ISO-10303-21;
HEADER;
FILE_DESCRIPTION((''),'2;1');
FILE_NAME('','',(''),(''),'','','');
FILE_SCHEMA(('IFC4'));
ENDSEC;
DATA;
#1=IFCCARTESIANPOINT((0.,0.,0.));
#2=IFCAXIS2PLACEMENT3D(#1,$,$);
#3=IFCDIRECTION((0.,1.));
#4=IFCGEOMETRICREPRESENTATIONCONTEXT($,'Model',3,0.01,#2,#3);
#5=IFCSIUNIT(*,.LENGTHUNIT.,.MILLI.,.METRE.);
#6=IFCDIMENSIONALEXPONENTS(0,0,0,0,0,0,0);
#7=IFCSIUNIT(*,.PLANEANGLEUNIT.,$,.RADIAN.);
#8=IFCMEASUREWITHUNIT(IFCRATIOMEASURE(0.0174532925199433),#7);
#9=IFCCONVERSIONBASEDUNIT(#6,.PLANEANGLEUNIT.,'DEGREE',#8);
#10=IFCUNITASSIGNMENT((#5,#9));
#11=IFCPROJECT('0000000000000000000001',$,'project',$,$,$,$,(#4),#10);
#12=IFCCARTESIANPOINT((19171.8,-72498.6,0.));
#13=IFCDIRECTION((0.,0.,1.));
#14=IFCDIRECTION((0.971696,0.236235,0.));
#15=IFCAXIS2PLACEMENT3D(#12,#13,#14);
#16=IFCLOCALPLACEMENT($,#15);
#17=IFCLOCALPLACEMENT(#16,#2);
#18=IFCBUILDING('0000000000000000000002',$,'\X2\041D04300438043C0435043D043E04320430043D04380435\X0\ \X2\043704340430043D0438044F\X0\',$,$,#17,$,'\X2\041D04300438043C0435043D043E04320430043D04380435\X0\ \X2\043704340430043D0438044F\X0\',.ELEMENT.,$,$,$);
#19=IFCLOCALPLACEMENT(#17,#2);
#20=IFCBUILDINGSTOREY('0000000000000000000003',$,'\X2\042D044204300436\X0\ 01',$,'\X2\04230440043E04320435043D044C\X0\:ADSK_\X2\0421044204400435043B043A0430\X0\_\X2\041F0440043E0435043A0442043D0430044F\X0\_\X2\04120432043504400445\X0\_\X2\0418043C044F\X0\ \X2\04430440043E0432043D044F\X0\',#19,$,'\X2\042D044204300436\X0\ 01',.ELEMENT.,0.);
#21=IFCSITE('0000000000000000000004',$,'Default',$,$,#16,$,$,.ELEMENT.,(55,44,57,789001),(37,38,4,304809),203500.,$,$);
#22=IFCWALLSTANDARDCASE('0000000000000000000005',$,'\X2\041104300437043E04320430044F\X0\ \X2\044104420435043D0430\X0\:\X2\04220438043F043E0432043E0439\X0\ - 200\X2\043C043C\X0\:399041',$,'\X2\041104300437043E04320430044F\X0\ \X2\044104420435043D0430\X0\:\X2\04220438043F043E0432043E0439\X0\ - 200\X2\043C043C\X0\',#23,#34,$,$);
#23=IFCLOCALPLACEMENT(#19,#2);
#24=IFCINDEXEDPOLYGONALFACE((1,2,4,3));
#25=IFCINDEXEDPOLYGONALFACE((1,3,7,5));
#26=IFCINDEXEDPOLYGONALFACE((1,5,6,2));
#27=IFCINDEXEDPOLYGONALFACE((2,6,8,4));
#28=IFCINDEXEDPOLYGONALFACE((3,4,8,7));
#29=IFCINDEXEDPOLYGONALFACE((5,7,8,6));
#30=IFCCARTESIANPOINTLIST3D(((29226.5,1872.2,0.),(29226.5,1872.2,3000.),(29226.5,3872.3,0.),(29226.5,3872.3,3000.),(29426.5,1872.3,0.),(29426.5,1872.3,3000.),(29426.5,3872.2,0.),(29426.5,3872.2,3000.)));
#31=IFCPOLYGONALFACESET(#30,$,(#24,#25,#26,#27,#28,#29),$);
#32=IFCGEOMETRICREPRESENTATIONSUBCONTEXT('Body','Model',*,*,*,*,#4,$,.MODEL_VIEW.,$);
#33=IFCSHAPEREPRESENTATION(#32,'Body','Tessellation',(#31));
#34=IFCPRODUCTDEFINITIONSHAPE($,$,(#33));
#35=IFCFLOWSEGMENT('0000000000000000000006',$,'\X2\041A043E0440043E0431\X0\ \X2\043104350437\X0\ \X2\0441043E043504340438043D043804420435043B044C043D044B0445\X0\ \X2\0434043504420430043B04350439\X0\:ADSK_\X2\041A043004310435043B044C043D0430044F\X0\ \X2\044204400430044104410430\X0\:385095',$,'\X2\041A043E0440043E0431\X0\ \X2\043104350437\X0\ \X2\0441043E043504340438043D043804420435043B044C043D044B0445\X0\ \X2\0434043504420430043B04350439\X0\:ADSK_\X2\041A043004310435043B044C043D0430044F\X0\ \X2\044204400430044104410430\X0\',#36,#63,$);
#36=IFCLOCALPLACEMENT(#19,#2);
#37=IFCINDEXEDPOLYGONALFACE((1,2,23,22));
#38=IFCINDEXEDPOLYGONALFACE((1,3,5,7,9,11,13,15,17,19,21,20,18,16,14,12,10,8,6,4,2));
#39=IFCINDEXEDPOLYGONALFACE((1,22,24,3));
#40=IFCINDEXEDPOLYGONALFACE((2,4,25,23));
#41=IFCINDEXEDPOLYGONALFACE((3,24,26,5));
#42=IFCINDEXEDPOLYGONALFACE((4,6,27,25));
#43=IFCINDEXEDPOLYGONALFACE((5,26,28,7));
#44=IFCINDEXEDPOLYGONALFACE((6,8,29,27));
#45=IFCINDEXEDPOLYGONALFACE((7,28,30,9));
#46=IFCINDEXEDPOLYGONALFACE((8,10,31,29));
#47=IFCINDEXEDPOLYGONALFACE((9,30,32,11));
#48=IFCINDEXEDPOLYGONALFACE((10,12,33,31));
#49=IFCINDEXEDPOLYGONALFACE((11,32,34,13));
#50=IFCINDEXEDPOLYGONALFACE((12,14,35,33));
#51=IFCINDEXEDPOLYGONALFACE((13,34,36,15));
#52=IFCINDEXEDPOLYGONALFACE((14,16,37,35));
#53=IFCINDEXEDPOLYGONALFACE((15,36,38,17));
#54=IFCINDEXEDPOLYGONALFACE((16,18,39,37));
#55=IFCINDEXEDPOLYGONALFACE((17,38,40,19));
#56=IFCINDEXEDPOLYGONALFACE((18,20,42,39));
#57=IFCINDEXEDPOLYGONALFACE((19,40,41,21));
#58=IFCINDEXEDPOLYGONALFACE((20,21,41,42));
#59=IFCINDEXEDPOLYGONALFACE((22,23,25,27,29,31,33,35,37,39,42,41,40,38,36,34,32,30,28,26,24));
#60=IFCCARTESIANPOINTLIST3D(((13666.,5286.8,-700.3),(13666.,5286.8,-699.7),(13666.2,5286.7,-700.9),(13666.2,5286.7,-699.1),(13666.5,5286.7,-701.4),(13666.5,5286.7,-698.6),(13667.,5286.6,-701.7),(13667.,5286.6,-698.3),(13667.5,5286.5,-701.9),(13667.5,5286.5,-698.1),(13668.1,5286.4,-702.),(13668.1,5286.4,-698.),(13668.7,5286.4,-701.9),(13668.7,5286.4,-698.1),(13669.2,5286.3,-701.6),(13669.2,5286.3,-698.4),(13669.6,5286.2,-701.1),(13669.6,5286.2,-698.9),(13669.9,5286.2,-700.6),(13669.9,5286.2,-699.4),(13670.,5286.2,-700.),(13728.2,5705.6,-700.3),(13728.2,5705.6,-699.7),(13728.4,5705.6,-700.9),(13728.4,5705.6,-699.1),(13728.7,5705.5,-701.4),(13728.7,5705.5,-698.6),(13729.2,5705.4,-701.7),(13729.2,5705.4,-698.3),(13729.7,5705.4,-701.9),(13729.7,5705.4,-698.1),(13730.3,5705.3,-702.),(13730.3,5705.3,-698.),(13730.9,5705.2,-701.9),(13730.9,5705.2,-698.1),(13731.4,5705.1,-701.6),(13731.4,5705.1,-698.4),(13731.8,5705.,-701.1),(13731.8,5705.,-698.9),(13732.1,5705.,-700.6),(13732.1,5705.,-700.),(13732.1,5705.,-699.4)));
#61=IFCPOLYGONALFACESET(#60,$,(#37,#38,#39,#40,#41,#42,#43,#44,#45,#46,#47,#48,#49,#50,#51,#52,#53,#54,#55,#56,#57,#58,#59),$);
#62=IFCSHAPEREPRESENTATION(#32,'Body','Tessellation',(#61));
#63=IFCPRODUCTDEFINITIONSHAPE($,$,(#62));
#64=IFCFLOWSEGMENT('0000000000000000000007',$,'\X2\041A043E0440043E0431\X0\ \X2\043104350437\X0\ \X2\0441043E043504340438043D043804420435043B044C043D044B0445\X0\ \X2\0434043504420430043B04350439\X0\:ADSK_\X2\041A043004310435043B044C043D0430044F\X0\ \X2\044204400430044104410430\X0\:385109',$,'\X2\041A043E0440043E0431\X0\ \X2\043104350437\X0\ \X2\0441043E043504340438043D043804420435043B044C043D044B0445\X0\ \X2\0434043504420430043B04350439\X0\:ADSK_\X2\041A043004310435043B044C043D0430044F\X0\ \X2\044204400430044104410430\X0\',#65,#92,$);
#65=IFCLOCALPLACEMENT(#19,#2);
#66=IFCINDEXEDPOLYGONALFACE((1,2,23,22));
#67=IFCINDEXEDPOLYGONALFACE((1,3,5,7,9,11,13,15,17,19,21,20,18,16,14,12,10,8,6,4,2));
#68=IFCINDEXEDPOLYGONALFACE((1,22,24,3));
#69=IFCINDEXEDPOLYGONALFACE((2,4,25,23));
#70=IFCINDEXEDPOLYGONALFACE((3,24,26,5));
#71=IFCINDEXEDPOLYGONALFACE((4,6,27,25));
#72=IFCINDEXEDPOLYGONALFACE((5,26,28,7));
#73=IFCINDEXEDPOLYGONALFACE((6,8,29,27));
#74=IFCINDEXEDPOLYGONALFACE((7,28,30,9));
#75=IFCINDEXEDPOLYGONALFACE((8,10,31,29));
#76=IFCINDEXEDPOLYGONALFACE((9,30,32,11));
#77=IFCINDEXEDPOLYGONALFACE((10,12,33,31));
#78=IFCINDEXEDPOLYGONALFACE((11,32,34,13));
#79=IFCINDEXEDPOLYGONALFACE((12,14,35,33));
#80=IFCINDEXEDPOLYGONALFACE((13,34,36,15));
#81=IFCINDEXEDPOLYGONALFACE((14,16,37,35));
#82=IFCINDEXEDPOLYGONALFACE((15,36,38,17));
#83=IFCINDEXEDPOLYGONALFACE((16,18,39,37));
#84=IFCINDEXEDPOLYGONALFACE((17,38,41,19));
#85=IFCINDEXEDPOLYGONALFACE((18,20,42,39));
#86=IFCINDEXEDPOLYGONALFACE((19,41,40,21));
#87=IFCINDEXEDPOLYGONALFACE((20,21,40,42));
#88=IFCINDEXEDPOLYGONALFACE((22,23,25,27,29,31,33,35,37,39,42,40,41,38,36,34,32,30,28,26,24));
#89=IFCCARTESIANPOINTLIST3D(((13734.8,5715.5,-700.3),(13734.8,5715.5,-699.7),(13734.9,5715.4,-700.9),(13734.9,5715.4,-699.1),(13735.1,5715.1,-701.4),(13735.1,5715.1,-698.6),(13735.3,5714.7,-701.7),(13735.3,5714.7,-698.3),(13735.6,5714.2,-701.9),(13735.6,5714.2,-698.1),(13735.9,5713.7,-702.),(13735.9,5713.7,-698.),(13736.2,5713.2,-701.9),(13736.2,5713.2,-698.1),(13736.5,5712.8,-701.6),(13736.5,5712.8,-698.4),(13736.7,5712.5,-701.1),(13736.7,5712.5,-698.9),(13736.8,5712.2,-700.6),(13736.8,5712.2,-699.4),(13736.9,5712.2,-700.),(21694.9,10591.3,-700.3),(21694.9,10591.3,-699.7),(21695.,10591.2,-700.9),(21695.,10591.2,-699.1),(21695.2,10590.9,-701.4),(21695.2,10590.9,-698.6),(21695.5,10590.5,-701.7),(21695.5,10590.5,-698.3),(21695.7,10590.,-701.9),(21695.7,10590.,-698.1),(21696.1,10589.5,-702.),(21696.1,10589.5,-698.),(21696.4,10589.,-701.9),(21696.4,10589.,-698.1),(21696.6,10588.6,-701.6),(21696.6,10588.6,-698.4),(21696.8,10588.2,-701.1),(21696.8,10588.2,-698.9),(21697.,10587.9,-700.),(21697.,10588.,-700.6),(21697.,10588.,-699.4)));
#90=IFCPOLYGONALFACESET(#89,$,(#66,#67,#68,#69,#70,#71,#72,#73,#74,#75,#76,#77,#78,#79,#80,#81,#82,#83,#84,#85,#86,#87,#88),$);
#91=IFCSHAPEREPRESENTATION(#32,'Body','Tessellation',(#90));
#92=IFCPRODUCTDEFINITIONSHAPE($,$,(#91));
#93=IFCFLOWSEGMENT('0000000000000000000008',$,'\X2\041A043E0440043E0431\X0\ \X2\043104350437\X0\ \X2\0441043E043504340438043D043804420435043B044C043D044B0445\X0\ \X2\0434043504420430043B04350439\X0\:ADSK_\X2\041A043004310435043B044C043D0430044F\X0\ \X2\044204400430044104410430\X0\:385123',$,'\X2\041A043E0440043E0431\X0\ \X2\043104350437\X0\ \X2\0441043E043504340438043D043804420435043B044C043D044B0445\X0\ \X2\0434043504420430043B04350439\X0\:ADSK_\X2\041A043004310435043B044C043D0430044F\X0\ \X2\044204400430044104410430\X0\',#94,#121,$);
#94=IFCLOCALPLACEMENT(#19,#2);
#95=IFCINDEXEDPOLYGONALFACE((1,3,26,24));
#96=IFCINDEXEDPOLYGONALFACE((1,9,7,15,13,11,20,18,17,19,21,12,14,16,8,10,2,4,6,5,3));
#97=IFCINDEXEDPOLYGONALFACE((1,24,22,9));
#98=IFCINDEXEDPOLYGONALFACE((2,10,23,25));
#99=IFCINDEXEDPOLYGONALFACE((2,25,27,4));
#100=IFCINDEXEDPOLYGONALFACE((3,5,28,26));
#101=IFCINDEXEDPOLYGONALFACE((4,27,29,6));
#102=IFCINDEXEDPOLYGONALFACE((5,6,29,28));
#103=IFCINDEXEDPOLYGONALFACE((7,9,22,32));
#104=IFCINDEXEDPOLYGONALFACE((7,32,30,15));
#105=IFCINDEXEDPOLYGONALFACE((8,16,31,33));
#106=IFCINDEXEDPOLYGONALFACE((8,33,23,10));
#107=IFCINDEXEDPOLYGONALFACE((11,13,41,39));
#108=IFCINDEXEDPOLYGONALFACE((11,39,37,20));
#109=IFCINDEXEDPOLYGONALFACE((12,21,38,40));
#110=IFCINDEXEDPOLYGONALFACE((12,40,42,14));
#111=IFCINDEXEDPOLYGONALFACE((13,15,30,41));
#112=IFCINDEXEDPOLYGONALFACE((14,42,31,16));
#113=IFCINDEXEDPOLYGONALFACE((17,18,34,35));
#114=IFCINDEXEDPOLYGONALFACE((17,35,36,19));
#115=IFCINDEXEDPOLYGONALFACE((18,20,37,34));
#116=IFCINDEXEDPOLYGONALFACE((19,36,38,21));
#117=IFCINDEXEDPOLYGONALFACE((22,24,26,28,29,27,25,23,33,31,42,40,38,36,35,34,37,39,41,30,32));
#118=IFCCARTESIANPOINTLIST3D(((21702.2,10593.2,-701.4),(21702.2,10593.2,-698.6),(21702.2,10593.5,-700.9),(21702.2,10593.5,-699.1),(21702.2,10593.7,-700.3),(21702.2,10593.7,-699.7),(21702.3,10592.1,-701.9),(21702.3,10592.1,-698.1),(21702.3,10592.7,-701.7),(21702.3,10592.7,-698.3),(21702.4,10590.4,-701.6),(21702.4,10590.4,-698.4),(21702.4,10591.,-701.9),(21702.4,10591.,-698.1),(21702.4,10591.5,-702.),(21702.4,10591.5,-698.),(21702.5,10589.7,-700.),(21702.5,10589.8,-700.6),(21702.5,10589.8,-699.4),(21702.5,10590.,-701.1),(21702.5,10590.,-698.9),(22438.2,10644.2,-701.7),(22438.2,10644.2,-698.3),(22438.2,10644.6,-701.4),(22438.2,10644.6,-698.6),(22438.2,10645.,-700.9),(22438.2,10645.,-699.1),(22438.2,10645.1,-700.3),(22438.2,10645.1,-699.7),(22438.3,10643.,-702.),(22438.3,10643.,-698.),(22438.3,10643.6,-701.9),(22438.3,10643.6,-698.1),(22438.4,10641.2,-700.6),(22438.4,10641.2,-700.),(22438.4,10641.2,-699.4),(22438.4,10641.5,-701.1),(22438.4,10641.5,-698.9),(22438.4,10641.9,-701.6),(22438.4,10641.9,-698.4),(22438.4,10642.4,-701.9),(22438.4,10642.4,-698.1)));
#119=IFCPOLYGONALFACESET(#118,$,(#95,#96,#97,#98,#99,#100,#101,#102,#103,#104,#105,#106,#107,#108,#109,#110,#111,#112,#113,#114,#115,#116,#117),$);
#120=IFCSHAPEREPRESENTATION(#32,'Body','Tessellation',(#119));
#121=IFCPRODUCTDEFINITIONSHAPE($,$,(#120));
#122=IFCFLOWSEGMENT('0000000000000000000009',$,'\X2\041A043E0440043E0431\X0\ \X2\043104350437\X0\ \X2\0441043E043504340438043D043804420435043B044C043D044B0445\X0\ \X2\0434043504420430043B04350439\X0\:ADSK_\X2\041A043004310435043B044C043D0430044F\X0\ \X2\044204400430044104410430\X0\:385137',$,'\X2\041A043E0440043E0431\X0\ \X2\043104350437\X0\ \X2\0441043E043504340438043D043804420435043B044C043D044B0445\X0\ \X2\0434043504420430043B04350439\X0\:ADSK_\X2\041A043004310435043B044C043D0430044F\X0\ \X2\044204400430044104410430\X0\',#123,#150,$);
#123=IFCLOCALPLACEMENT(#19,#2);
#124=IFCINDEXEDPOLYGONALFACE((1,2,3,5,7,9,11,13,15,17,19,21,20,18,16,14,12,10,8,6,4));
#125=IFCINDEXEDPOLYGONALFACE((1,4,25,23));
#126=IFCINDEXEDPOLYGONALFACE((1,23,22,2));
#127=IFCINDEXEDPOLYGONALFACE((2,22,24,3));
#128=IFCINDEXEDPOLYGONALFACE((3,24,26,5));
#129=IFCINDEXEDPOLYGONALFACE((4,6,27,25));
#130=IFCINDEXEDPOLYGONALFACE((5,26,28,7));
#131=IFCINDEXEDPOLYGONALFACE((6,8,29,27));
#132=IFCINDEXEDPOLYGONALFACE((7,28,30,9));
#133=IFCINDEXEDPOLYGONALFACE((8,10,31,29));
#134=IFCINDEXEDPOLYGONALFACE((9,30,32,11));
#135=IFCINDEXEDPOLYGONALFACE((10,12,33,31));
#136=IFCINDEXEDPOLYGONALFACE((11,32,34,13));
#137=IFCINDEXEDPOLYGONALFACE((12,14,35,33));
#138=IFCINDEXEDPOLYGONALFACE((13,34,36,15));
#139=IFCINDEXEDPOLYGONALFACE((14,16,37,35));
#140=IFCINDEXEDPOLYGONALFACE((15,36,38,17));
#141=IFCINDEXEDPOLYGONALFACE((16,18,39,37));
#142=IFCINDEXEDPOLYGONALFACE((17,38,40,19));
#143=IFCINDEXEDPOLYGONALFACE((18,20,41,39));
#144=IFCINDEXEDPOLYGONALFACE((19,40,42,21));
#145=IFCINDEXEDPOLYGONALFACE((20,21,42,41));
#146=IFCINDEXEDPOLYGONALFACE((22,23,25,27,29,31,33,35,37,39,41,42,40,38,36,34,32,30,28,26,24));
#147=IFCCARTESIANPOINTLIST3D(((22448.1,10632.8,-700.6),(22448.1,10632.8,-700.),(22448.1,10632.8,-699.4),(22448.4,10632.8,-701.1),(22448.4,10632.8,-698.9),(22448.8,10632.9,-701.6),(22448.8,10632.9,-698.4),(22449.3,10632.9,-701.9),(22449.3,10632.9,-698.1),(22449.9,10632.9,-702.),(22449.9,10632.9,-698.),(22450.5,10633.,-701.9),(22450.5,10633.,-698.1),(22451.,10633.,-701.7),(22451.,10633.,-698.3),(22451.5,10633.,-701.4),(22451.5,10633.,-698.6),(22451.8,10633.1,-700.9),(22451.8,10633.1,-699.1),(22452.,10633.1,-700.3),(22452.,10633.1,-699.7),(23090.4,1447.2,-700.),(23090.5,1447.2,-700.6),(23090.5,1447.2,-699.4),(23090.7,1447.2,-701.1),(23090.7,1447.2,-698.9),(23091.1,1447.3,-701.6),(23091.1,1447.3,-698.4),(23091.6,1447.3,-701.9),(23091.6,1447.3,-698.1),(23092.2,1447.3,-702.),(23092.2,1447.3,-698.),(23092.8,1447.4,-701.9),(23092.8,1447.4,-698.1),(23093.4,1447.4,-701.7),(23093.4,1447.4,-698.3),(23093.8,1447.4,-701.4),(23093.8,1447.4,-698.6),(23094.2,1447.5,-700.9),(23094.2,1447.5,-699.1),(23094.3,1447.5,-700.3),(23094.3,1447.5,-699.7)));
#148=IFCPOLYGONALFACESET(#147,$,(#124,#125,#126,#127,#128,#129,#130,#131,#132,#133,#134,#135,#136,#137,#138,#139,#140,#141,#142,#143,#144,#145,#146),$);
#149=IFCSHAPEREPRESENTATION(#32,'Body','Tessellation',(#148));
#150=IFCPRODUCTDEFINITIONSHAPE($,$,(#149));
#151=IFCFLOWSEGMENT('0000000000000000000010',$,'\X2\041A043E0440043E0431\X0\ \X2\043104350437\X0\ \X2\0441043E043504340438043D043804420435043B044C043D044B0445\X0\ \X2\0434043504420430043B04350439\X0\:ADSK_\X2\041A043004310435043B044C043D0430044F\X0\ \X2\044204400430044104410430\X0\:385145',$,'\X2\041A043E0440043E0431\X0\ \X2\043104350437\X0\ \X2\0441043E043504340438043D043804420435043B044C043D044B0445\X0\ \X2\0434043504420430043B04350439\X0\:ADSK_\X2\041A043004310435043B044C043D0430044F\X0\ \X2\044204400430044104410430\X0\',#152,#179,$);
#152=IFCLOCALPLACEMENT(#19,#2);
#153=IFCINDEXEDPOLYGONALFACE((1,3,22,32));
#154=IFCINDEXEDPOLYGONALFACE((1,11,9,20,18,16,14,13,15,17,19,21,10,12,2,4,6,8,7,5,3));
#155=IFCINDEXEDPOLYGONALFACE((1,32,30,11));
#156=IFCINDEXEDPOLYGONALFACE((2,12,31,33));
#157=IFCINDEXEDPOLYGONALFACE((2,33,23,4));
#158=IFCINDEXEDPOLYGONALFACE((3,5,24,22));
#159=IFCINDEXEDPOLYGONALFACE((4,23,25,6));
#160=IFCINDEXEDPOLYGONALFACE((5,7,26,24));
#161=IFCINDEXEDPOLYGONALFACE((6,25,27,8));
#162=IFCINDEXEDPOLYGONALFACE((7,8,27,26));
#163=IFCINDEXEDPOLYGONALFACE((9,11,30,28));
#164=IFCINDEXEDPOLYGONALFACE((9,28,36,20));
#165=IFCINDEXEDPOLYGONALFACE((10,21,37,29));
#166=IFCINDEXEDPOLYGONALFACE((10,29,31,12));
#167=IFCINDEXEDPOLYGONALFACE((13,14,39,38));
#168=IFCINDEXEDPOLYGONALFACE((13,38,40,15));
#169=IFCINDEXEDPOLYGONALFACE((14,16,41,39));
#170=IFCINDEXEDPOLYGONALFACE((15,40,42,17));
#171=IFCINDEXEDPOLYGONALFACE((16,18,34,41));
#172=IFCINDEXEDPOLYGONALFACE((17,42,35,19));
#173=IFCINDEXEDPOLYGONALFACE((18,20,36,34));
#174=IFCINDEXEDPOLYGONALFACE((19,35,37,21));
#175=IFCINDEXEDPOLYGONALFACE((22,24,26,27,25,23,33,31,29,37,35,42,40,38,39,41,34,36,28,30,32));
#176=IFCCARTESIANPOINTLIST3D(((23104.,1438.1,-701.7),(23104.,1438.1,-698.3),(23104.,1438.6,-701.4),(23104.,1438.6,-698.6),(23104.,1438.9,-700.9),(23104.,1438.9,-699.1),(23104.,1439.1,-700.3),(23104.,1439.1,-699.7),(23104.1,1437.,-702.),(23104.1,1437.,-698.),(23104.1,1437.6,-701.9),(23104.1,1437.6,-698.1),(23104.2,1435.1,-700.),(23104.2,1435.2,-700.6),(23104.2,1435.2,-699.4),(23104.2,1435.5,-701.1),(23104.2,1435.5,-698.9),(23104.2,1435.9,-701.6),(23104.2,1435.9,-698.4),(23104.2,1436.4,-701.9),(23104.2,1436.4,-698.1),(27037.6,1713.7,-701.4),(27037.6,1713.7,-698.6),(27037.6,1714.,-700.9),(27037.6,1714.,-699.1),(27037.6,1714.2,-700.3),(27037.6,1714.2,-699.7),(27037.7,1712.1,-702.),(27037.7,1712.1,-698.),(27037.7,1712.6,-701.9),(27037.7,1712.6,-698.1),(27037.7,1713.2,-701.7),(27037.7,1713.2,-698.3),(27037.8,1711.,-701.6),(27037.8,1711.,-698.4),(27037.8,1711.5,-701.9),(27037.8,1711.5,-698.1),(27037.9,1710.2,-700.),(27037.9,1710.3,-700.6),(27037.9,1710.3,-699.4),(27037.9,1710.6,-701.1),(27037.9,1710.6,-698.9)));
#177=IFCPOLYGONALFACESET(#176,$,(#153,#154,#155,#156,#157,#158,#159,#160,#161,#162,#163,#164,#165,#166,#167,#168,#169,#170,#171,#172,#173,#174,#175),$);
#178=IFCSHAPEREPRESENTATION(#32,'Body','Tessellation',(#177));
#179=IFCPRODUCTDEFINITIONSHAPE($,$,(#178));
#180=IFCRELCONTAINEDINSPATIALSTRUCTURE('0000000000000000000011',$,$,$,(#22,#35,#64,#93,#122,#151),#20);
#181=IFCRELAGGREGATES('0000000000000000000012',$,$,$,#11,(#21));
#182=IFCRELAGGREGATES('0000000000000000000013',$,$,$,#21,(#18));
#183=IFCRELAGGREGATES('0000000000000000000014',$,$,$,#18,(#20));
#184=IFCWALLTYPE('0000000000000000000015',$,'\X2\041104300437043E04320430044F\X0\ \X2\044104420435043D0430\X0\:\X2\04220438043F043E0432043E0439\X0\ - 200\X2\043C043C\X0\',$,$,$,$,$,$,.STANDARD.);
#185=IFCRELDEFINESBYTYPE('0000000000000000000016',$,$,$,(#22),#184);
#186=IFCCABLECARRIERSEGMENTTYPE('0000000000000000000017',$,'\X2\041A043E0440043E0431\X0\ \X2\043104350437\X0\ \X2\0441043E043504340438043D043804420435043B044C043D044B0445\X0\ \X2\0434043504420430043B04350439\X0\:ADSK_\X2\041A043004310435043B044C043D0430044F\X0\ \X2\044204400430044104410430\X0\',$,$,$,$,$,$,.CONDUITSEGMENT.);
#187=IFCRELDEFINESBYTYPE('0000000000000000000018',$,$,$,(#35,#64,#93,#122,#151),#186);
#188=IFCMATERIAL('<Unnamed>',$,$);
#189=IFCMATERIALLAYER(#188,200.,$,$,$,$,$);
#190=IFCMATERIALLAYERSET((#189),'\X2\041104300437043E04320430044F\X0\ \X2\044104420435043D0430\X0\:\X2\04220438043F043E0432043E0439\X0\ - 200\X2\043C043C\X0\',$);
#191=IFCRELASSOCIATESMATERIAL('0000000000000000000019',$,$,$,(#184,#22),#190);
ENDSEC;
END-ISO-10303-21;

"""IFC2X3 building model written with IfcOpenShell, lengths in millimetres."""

from ifc_helpers import new_model, entity, si_unit, converted_unit, direction, frame, frame_2d, origin, origin_2d_with_axis, place, context, subcontext, project, spatial, rectangle, circle, extrude, material, layer, layer_set, layer_usage, type_object, element, save


model = new_model("IFC2X3")

# Units and contexts
model_context = context("Model", 3, precision=0.01, world=origin(), true_north=direction((0.0, 1.0)))
body_context = subcontext(model_context, "Body", "Model", "MODEL_VIEW")
ifc_project = project(units=[si_unit("LENGTHUNIT", "METRE", prefix="MILLI"), converted_unit("PLANEANGLEUNIT", "DEGREE", entity("IfcRatioMeasure", 0.0174532925199433), si_unit("PLANEANGLEUNIT", "RADIAN"), dimensions=[0, 0, 0, 0, 0, 0, 0])], contexts=[model_context])

# Site, building, storey
site_placement = place(None, frame((19171.8, -72498.6, 0.0), z_axis=(0.0, 0.0, 1.0), x_axis=(0.971696, 0.236235, 0.0)))
site = spatial("IfcSite", under=ifc_project, at=site_placement, Name="Default", CompositionType="ELEMENT", RefLatitude=(55, 44, 57, 789001), RefLongitude=(37, 38, 4, 304809), RefElevation=203500.0)
building_placement = place(site_placement, origin())
building = spatial("IfcBuilding", under=site, at=building_placement, Name="Наименование здания", LongName="Наименование здания", CompositionType="ELEMENT")
storey_placement = place(building_placement, origin())
storey = spatial("IfcBuildingStorey", under=building, at=storey_placement, Name="Этаж 01", ObjectType="Уровень:ADSK_Стрелка_Проектная_Вверх_Имя уровня", LongName="Этаж 01", CompositionType="ELEMENT", Elevation=0.0)

# Wall
ifc_material = material(Name="<Unnamed>")
ifc_layer = layer(ifc_material, 200.0)
ifc_layer_set = layer_set([ifc_layer], Name="Базовая стена:Типовой - 200мм")
ifc_layer_usage = layer_usage(ifc_layer_set, "AXIS2", "NEGATIVE", 100.0)
wall_type = type_object("IfcWallType", Name="Базовая стена:Типовой - 200мм", PredefinedType="STANDARD", material=ifc_layer_set)
wall_placement = place(storey_placement, frame((29326.5, 3872.2, 0.0), z_axis=(0.0, 0.0, 1.0), x_axis=(0.0, -1.0, 0.0)))
element("IfcWallStandardCase", 1, at=wall_placement, inside=storey, type_object=wall_type, material=ifc_layer_usage, Name="Базовая стена:Типовой - 200мм:399041", ObjectType="Базовая стена:Типовой - 200мм", context=body_context, shape_type="SweptSolid", body=[
    extrude(rectangle(XDim=2000.0, YDim=200.0, at=frame_2d((1000.0, 0.0), x_axis=(-1.0, 0.0))), origin(), (0.0, 0.0, 1.0), 3000.0),
])

# Flow segments
cable_carrier_segment_type_1 = type_object("IfcCableCarrierSegmentType", Name="Короб без соединительных деталей:ADSK_Кабельная трасса", PredefinedType="CONDUITSEGMENT")
flow_segment_1_placement = place(storey_placement, frame((13664.4, 5284.6, -703.6)))
element("IfcFlowSegment", 2, at=flow_segment_1_placement, inside=storey, type_object=cable_carrier_segment_type_1, Name="Короб без соединительных деталей:ADSK_Кабельная трасса:385095", ObjectType="Короб без соединительных деталей:ADSK_Кабельная трасса", context=body_context, shape_type="SweptSolid", body=[
    extrude(circle(Radius=2.0, at=origin_2d_with_axis()), frame((3.6, 1.9, 3.6), z_axis=(0.146835, 0.989161, 0.0), x_axis=(0.989161, -0.146835, 0.0)), (0.0, 0.0, 1.0), 423.4),
])
flow_segment_2_placement = place(storey_placement, frame((13733.2, 5710.6, -703.6)))
element("IfcFlowSegment", 3, at=flow_segment_2_placement, inside=storey, type_object=cable_carrier_segment_type_1, Name="Короб без соединительных деталей:ADSK_Кабельная трасса:385109", ObjectType="Короб без соединительных деталей:ADSK_Кабельная трасса", context=body_context, shape_type="SweptSolid", body=[
    extrude(circle(Radius=2.0, at=origin_2d_with_axis()), frame((2.6, 3.3, 3.6), z_axis=(0.852745, 0.522328, 0.0), x_axis=(0.522328, -0.852745, 0.0)), (0.0, 0.0, 1.0), 9334.7),
])
flow_segment_3_placement = place(storey_placement, frame((21702.2, 10588.1, -703.6)))
element("IfcFlowSegment", 4, at=flow_segment_3_placement, inside=storey, type_object=cable_carrier_segment_type_1, Name="Короб без соединительных деталей:ADSK_Кабельная трасса:385123", ObjectType="Короб без соединительных деталей:ADSK_Кабельная трасса", context=body_context, shape_type="SweptSolid", body=[
    extrude(circle(Radius=2.0, at=origin_2d_with_axis()), frame((0.1, 3.6, 3.6), z_axis=(0.997564, 0.069756, 0.0), x_axis=(0.069756, -0.997564, 0.0)), (0.0, 0.0, 1.0), 737.8),
])
flow_segment_4_placement = place(storey_placement, frame((22446.5, 1447.2, -703.6)))
element("IfcFlowSegment", 5, at=flow_segment_4_placement, inside=storey, type_object=cable_carrier_segment_type_1, Name="Короб без соединительных деталей:ADSK_Кабельная трасса:385137", ObjectType="Короб без соединительных деталей:ADSK_Кабельная трасса", context=body_context, shape_type="SweptSolid", body=[
    extrude(circle(Radius=2.0, at=origin_2d_with_axis()), frame((3.6, 9185.7, 3.6), z_axis=(0.069756, -0.997564, 0.0), x_axis=(-0.997564, -0.069756, 0.0)), (0.0, 0.0, 1.0), 9208.0),
])
flow_segment_5_placement = place(storey_placement, frame((23104.0, 1433.5, -703.6)))
element("IfcFlowSegment", 6, at=flow_segment_5_placement, inside=storey, type_object=cable_carrier_segment_type_1, Name="Короб без соединительных деталей:ADSK_Кабельная трасса:385145", ObjectType="Короб без соединительных деталей:ADSK_Кабельная трасса", context=body_context, shape_type="SweptSolid", body=[
    extrude(circle(Radius=2.0, at=origin_2d_with_axis()), frame((0.1, 3.6, 3.6), z_axis=(0.997564, 0.069756, 0.0), x_axis=(0.069756, -0.997564, 0.0)), (0.0, 0.0, 1.0), 3943.2),
])

save(model, "model.ifc")
